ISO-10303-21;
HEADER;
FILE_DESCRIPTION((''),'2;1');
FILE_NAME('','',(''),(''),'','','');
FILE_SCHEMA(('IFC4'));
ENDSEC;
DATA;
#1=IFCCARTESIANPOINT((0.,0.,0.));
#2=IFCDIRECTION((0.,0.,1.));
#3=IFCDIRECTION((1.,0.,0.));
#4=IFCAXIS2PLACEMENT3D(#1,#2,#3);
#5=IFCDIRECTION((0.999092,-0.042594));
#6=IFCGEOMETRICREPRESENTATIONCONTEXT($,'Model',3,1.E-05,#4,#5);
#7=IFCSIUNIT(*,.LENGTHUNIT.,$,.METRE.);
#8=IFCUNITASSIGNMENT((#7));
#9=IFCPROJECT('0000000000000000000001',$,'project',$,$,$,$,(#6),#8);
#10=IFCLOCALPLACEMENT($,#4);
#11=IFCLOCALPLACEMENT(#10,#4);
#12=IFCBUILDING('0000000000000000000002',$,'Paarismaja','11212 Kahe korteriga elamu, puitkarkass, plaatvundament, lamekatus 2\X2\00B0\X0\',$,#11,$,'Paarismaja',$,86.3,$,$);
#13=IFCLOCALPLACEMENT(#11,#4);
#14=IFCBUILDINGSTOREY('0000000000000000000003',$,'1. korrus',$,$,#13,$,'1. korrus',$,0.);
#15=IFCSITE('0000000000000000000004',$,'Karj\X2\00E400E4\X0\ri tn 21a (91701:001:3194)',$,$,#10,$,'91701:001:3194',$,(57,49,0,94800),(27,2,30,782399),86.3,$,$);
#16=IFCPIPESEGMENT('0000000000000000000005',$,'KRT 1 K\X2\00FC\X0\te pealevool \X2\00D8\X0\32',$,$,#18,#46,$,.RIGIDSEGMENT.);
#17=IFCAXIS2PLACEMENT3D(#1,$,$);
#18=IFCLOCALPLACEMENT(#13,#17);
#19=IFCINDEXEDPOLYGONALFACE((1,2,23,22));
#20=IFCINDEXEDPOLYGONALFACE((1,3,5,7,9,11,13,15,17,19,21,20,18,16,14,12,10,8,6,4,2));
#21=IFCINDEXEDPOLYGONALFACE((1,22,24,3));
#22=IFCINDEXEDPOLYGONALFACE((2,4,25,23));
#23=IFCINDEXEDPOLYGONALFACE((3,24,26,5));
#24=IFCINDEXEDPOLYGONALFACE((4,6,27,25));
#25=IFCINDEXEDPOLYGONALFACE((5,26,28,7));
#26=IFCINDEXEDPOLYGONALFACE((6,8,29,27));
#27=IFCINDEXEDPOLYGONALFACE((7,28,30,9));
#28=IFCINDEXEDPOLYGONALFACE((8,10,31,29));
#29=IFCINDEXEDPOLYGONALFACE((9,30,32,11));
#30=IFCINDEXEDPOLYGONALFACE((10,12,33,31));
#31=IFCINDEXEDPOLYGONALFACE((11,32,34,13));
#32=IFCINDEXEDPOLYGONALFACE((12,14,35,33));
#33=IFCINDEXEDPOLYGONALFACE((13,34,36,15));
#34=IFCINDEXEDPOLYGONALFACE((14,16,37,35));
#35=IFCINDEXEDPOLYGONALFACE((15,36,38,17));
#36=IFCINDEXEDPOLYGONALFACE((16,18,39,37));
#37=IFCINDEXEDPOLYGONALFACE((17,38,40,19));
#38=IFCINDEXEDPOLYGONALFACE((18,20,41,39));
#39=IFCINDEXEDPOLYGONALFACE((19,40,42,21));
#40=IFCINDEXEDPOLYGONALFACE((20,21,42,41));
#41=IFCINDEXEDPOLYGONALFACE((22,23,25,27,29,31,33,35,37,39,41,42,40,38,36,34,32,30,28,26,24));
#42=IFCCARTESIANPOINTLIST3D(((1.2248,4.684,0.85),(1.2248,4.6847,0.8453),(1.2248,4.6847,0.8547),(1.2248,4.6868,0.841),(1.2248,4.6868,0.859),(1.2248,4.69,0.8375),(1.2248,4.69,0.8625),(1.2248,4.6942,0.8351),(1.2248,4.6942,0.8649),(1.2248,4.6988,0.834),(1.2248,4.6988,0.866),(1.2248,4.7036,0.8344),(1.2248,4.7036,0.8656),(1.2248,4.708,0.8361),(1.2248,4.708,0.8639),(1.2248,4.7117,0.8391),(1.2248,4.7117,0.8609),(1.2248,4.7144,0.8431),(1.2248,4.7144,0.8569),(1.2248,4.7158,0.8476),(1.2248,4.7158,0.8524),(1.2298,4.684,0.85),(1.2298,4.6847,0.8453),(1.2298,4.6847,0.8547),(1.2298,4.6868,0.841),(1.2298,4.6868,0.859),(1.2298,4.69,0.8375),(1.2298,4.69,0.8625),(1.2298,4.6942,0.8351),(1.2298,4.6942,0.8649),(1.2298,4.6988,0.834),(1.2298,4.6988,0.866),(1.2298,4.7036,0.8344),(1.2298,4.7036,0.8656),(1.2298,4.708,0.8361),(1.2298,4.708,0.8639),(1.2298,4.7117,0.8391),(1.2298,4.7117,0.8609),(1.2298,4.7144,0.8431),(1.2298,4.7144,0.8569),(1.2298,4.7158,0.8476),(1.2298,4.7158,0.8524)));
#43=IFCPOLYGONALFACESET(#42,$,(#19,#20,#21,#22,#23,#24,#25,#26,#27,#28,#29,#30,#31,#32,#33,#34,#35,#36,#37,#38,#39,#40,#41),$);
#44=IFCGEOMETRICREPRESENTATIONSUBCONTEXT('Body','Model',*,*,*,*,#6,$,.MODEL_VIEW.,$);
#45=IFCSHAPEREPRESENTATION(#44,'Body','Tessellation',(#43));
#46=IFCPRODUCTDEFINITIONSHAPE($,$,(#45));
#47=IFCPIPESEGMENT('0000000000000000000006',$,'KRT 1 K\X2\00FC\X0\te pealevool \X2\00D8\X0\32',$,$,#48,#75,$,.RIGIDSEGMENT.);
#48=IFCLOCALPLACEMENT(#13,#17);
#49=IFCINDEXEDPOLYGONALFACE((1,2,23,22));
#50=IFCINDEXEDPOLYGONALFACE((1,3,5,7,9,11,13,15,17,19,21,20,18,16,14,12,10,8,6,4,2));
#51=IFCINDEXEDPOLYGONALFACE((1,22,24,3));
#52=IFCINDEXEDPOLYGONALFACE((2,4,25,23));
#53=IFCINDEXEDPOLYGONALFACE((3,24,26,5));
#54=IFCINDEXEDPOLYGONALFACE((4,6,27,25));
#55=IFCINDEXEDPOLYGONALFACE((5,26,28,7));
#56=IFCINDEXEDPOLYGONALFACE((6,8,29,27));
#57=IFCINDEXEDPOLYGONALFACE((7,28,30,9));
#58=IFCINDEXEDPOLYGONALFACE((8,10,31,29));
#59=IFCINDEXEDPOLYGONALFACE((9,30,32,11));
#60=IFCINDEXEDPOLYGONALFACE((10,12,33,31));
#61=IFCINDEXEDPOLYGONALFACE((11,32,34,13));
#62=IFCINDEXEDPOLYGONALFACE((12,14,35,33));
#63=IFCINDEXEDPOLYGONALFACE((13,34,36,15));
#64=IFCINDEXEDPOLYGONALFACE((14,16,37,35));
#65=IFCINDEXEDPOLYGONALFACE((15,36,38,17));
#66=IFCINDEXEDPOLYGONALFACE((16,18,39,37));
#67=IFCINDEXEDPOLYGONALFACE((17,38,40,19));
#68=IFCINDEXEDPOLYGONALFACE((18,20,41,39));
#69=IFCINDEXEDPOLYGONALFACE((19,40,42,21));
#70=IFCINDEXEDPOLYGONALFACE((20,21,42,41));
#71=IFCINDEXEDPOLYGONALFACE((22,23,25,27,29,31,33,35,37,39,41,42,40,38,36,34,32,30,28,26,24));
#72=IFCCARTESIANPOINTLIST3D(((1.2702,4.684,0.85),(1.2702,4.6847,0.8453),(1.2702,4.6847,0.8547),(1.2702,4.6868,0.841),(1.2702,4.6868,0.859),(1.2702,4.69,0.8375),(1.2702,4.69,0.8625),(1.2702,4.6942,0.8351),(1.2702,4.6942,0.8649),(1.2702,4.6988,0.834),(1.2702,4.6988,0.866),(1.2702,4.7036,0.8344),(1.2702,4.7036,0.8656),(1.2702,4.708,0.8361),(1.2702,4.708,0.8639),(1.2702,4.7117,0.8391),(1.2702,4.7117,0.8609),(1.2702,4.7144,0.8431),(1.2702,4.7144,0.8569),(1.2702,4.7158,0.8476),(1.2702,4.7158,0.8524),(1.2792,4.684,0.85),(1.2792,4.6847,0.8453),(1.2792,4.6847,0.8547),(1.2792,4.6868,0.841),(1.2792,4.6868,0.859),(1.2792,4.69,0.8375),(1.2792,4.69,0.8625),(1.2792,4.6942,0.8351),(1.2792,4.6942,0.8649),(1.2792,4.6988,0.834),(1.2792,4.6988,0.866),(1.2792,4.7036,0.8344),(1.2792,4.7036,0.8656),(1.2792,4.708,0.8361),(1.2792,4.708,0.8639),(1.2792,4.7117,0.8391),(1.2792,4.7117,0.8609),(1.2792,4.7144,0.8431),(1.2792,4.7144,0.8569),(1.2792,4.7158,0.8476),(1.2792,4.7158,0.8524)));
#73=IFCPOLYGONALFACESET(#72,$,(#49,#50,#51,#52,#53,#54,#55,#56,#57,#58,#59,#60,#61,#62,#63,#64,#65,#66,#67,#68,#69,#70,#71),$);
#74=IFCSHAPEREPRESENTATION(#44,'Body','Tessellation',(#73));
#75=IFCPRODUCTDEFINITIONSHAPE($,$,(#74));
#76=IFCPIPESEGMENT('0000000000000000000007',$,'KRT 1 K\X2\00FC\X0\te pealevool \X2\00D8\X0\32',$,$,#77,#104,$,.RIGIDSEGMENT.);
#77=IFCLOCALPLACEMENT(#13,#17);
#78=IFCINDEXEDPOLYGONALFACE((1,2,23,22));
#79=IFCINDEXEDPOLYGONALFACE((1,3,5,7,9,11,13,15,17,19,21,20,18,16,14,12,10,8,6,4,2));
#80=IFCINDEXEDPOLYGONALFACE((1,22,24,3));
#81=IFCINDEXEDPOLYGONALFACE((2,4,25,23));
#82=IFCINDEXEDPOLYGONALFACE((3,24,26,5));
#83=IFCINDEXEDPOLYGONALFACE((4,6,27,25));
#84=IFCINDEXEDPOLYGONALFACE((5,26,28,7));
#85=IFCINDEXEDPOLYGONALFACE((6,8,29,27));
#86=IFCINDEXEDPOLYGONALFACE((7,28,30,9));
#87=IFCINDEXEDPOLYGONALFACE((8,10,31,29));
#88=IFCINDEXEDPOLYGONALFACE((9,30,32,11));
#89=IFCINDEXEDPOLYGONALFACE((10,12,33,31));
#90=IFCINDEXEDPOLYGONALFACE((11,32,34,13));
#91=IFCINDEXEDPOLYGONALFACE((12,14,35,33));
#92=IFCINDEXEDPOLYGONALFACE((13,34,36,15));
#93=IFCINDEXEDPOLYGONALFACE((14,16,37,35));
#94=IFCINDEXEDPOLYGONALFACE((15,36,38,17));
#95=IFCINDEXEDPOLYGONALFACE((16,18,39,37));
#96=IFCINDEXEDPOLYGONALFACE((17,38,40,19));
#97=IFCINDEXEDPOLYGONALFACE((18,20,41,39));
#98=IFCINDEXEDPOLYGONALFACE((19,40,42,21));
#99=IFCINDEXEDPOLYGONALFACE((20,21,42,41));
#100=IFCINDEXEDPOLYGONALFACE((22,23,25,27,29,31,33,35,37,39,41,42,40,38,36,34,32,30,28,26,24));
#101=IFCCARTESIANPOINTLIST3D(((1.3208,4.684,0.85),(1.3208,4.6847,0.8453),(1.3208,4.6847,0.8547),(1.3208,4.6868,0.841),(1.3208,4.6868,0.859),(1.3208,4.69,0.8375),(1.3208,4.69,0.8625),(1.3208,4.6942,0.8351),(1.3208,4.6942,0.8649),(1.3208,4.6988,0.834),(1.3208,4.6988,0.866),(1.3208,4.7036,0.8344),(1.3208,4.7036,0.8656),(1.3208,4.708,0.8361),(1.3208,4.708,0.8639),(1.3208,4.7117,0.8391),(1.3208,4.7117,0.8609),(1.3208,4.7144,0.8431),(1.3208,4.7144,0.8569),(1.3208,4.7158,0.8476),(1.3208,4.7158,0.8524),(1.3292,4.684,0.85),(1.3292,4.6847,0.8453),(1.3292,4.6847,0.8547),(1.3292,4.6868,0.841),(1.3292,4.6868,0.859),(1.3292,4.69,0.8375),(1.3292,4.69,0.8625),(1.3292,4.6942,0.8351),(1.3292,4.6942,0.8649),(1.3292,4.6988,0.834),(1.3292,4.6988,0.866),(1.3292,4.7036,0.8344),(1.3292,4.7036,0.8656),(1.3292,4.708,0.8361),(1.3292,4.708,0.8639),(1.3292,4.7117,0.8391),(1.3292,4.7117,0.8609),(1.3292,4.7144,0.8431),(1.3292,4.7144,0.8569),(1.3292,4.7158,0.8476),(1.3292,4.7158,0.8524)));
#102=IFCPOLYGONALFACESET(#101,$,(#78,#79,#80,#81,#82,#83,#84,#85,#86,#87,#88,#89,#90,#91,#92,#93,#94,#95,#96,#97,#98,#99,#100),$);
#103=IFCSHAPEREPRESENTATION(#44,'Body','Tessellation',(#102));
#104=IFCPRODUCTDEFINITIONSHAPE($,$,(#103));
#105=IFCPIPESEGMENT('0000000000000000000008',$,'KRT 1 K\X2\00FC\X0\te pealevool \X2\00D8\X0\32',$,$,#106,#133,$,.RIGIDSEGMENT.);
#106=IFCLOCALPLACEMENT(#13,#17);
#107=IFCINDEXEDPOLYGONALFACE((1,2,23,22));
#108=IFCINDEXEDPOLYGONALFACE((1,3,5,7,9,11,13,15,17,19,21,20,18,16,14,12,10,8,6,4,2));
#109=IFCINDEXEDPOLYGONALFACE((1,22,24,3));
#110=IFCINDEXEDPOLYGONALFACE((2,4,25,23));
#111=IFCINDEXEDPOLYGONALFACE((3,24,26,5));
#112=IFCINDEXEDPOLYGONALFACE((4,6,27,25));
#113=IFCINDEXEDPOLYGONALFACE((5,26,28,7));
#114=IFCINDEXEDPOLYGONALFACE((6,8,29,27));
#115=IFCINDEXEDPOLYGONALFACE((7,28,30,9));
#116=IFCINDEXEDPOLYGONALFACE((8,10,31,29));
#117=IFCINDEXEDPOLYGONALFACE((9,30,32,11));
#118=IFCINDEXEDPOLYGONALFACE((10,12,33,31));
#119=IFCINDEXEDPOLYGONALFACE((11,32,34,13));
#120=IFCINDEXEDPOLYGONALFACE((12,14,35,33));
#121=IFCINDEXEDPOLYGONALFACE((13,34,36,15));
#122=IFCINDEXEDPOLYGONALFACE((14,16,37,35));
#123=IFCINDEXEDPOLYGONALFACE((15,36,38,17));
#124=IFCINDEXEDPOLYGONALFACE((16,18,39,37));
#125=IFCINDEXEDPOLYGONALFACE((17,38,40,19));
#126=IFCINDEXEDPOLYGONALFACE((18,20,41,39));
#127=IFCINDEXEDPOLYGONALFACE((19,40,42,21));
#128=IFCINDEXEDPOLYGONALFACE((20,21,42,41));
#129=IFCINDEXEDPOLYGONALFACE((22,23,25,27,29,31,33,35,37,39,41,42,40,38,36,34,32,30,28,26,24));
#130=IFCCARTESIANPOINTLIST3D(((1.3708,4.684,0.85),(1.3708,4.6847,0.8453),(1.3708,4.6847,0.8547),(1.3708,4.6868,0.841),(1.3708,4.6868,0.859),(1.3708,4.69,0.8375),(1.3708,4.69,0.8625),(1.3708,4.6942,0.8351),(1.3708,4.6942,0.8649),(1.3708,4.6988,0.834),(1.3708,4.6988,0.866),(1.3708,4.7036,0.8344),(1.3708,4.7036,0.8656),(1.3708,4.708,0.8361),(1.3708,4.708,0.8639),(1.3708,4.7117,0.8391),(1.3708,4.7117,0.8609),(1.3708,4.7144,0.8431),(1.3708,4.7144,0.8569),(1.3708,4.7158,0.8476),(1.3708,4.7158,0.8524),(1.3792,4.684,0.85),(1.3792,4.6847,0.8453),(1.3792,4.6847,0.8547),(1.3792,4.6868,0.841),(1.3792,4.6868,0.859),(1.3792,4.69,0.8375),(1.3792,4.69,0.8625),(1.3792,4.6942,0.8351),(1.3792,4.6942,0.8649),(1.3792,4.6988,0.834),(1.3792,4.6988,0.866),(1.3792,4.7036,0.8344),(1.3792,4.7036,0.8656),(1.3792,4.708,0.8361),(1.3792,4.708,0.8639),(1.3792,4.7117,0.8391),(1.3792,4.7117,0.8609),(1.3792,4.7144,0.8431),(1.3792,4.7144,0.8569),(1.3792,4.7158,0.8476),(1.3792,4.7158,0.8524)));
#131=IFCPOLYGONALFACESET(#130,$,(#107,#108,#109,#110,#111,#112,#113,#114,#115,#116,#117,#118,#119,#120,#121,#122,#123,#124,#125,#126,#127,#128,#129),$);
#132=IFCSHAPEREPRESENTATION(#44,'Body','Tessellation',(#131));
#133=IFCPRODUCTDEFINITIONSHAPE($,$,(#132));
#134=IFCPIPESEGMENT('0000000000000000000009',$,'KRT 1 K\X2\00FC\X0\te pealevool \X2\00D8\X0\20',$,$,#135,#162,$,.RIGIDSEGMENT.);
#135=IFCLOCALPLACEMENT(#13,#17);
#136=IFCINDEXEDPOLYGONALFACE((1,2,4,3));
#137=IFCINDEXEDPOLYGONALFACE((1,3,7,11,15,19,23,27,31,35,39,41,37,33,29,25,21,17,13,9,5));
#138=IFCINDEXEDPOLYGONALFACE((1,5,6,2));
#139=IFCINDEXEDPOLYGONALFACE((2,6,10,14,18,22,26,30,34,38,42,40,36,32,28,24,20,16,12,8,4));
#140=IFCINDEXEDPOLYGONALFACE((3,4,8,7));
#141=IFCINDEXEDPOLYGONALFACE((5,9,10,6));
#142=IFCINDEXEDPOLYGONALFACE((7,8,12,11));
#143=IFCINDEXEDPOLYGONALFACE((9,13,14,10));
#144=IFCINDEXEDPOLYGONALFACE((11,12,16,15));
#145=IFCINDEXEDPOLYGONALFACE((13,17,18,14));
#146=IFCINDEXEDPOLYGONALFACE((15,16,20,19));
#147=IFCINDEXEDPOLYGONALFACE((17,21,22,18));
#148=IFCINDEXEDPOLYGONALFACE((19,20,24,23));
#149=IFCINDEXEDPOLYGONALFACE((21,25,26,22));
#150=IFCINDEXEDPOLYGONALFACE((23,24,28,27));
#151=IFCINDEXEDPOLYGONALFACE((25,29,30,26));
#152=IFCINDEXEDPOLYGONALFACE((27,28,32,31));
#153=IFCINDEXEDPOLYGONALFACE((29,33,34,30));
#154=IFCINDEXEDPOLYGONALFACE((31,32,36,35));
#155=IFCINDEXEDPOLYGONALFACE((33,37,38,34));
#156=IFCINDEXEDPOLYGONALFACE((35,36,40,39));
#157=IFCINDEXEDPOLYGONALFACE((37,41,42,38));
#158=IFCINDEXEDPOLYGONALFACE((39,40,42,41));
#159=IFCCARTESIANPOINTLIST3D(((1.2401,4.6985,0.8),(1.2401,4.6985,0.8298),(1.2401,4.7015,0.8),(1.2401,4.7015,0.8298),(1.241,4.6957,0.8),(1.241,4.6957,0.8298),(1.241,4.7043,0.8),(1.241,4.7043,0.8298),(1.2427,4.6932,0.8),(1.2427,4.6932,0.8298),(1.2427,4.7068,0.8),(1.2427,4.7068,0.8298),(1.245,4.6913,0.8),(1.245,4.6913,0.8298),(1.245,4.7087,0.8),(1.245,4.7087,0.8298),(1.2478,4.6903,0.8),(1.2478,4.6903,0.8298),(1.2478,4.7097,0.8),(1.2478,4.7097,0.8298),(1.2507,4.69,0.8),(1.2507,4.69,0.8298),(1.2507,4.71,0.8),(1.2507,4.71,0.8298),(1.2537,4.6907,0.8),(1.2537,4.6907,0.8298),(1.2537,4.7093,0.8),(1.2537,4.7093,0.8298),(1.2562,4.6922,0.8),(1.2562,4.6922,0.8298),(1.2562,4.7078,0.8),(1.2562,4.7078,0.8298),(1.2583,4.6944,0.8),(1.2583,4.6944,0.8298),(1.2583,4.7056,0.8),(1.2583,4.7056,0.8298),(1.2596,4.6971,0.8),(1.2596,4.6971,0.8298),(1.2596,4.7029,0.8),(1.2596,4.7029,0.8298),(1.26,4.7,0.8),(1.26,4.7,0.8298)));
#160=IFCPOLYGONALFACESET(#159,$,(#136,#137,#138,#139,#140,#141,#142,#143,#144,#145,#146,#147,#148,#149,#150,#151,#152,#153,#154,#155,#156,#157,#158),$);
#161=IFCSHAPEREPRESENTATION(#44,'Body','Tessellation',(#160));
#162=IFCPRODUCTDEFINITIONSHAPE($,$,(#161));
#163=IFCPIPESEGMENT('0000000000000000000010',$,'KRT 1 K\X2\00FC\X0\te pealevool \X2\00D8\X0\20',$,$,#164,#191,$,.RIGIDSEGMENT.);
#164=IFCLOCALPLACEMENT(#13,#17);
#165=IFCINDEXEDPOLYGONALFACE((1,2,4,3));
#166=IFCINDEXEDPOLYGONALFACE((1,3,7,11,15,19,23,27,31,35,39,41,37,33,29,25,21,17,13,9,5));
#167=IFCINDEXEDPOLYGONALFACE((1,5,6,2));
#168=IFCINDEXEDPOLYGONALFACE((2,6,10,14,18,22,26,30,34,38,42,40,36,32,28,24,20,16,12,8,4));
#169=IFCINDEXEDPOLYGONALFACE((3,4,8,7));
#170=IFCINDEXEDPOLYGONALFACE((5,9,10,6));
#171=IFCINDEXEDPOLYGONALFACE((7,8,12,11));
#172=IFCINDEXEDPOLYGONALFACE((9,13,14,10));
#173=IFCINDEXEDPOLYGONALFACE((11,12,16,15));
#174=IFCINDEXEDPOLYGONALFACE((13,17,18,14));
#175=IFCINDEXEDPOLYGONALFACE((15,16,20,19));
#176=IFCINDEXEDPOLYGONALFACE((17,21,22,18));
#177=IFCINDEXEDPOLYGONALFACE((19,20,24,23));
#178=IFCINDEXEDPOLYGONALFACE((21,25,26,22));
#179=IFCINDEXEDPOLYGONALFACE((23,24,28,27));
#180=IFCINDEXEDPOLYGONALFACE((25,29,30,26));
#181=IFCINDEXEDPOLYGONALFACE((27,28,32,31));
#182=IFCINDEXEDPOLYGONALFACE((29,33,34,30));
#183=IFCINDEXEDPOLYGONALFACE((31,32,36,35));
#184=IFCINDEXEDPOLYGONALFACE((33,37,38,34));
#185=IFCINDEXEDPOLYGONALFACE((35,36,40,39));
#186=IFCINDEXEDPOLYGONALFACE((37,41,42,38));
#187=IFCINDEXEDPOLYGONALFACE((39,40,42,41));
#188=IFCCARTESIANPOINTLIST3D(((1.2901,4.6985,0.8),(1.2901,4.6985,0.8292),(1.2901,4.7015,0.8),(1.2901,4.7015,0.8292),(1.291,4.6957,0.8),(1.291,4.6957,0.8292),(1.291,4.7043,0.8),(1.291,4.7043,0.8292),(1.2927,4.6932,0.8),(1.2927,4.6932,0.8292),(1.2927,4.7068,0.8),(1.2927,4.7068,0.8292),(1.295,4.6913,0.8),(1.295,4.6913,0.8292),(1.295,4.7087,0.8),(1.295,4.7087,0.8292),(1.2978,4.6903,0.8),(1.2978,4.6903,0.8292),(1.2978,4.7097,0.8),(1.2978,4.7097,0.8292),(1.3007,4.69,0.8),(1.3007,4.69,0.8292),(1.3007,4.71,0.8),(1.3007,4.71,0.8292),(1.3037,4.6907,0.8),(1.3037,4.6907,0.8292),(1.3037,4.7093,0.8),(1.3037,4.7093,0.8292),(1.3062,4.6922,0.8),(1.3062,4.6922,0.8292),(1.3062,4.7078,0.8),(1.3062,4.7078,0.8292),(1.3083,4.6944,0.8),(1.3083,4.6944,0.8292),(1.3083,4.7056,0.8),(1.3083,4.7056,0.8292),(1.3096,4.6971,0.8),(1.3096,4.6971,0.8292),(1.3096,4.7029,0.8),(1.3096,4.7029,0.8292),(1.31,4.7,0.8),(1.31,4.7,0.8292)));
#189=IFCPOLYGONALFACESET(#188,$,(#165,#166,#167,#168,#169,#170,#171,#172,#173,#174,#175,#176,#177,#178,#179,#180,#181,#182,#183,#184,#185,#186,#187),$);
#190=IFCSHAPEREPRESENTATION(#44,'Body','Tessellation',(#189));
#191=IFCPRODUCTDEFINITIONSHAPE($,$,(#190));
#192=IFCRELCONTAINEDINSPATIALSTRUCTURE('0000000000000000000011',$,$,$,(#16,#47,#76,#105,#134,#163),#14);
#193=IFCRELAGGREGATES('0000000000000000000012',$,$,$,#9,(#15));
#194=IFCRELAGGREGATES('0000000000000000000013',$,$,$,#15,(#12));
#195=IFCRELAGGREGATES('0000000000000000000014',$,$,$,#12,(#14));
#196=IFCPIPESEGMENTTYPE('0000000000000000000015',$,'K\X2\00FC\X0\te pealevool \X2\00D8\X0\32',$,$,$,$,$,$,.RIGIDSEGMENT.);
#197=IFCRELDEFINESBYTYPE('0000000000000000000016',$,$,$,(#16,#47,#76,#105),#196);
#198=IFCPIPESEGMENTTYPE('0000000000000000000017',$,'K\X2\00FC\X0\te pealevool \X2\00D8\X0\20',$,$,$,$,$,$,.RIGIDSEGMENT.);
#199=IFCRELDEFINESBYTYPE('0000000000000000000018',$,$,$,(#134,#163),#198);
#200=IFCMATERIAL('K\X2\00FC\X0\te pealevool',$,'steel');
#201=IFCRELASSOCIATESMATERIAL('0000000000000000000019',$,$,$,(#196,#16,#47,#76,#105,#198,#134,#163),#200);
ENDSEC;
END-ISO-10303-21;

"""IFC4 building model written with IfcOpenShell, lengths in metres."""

from ifc_helpers import new_model, si_unit, direction, frame, origin_with_axes, place, context, subcontext, project, spatial, circle, extrude, material, type_object, element, save


model = new_model("IFC4")

# Units and contexts
model_context = context("Model", 3, precision=1e-05, world=origin_with_axes(), true_north=direction((0.999092, -0.042594)))
body_context = subcontext(model_context, "Body", "Model", "MODEL_VIEW")
ifc_project = project(units=[si_unit("LENGTHUNIT", "METRE")], contexts=[model_context])

# Site, building, storey
site_placement = place(None, origin_with_axes())
site = spatial("IfcSite", under=ifc_project, at=site_placement, Name="Karjääri tn 21a (91701:001:3194)", LongName="91701:001:3194", RefLatitude=(57, 49, 0, 94800), RefLongitude=(27, 2, 30, 782399), RefElevation=86.3)
building_placement = place(site_placement, origin_with_axes())
building = spatial("IfcBuilding", under=site, at=building_placement, Name="Paarismaja", Description="11212 Kahe korteriga elamu, puitkarkass, plaatvundament, lamekatus 2°", LongName="Paarismaja", ElevationOfRefHeight=86.3)
storey_placement = place(building_placement, origin_with_axes())
storey = spatial("IfcBuildingStorey", under=building, at=storey_placement, Name="1. korrus", LongName="1. korrus", Elevation=0.0)

# Shared definitions
ifc_material_1 = material(Name="Küte pealevool", Category="steel")

# Pipe segments
pipe_segment_type_1 = type_object("IfcPipeSegmentType", Name="Küte pealevool Ø32", PredefinedType="RIGIDSEGMENT", material=ifc_material_1)
pipe_segment_1_placement = place(storey_placement, frame((1.2248, 4.7, 0.85), z_axis=(1.0, 0.0, 0.0), x_axis=(0.0, -1.0, 0.0)))
element("IfcPipeSegment", 1, at=pipe_segment_1_placement, inside=storey, type_object=pipe_segment_type_1, material=ifc_material_1, Name="KRT 1 Küte pealevool Ø32", PredefinedType="RIGIDSEGMENT", context=body_context, shape_type="SweptSolid", body=[
    extrude(circle(Radius=0.016), origin_with_axes(), (0.0, 0.0, 1.0), 0.005),
])
pipe_segment_2_placement = place(storey_placement, frame((1.2702, 4.7, 0.85), z_axis=(1.0, 0.0, 0.0), x_axis=(0.0, -1.0, 0.0)))
element("IfcPipeSegment", 2, at=pipe_segment_2_placement, inside=storey, type_object=pipe_segment_type_1, material=ifc_material_1, Name="KRT 1 Küte pealevool Ø32", PredefinedType="RIGIDSEGMENT", context=body_context, shape_type="SweptSolid", body=[
    extrude(circle(Radius=0.016), origin_with_axes(), (0.0, 0.0, 1.0), 0.009),
])
pipe_segment_3_placement = place(storey_placement, frame((1.3208, 4.7, 0.85), z_axis=(1.0, 0.0, 0.0), x_axis=(0.0, -1.0, 0.0)))
element("IfcPipeSegment", 3, at=pipe_segment_3_placement, inside=storey, type_object=pipe_segment_type_1, material=ifc_material_1, Name="KRT 1 Küte pealevool Ø32", PredefinedType="RIGIDSEGMENT", context=body_context, shape_type="SweptSolid", body=[
    extrude(circle(Radius=0.016), origin_with_axes(), (0.0, 0.0, 1.0), 0.0084),
])
pipe_segment_4_placement = place(storey_placement, frame((1.3708, 4.7, 0.85), z_axis=(1.0, 0.0, 0.0), x_axis=(0.0, -1.0, 0.0)))
element("IfcPipeSegment", 4, at=pipe_segment_4_placement, inside=storey, type_object=pipe_segment_type_1, material=ifc_material_1, Name="KRT 1 Küte pealevool Ø32", PredefinedType="RIGIDSEGMENT", context=body_context, shape_type="SweptSolid", body=[
    extrude(circle(Radius=0.016), origin_with_axes(), (0.0, 0.0, 1.0), 0.0084),
])
pipe_segment_type_2 = type_object("IfcPipeSegmentType", Name="Küte pealevool Ø20", PredefinedType="RIGIDSEGMENT", material=ifc_material_1)
pipe_segment_5_placement = place(storey_placement, frame((1.25, 4.7, 0.8298), z_axis=(0.0, 0.0, -1.0), x_axis=(1.0, 0.0, 0.0)))
element("IfcPipeSegment", 5, at=pipe_segment_5_placement, inside=storey, type_object=pipe_segment_type_2, material=ifc_material_1, Name="KRT 1 Küte pealevool Ø20", PredefinedType="RIGIDSEGMENT", context=body_context, shape_type="SweptSolid", body=[
    extrude(circle(Radius=0.01), origin_with_axes(), (0.0, 0.0, 1.0), 0.0298),
])
for number, where, z_axis, x_axis, name in (
    (6, (1.3, 4.7, 0.8292), (0.0, 0.0, -1.0), (1.0, 0.0, 0.0), "KRT 1 Küte pealevool Ø20"),
):
    element("IfcPipeSegment", number, at=place(storey_placement, frame(where, z_axis=z_axis, x_axis=x_axis)), inside=storey, type_object=pipe_segment_type_2, material=ifc_material_1, Name=name, PredefinedType="RIGIDSEGMENT", context=body_context, shape_type="SweptSolid", body=[
        extrude(circle(Radius=0.01), origin_with_axes(), (0.0, 0.0, 1.0), 0.0292),
    ])

save(model, "model.ifc")
